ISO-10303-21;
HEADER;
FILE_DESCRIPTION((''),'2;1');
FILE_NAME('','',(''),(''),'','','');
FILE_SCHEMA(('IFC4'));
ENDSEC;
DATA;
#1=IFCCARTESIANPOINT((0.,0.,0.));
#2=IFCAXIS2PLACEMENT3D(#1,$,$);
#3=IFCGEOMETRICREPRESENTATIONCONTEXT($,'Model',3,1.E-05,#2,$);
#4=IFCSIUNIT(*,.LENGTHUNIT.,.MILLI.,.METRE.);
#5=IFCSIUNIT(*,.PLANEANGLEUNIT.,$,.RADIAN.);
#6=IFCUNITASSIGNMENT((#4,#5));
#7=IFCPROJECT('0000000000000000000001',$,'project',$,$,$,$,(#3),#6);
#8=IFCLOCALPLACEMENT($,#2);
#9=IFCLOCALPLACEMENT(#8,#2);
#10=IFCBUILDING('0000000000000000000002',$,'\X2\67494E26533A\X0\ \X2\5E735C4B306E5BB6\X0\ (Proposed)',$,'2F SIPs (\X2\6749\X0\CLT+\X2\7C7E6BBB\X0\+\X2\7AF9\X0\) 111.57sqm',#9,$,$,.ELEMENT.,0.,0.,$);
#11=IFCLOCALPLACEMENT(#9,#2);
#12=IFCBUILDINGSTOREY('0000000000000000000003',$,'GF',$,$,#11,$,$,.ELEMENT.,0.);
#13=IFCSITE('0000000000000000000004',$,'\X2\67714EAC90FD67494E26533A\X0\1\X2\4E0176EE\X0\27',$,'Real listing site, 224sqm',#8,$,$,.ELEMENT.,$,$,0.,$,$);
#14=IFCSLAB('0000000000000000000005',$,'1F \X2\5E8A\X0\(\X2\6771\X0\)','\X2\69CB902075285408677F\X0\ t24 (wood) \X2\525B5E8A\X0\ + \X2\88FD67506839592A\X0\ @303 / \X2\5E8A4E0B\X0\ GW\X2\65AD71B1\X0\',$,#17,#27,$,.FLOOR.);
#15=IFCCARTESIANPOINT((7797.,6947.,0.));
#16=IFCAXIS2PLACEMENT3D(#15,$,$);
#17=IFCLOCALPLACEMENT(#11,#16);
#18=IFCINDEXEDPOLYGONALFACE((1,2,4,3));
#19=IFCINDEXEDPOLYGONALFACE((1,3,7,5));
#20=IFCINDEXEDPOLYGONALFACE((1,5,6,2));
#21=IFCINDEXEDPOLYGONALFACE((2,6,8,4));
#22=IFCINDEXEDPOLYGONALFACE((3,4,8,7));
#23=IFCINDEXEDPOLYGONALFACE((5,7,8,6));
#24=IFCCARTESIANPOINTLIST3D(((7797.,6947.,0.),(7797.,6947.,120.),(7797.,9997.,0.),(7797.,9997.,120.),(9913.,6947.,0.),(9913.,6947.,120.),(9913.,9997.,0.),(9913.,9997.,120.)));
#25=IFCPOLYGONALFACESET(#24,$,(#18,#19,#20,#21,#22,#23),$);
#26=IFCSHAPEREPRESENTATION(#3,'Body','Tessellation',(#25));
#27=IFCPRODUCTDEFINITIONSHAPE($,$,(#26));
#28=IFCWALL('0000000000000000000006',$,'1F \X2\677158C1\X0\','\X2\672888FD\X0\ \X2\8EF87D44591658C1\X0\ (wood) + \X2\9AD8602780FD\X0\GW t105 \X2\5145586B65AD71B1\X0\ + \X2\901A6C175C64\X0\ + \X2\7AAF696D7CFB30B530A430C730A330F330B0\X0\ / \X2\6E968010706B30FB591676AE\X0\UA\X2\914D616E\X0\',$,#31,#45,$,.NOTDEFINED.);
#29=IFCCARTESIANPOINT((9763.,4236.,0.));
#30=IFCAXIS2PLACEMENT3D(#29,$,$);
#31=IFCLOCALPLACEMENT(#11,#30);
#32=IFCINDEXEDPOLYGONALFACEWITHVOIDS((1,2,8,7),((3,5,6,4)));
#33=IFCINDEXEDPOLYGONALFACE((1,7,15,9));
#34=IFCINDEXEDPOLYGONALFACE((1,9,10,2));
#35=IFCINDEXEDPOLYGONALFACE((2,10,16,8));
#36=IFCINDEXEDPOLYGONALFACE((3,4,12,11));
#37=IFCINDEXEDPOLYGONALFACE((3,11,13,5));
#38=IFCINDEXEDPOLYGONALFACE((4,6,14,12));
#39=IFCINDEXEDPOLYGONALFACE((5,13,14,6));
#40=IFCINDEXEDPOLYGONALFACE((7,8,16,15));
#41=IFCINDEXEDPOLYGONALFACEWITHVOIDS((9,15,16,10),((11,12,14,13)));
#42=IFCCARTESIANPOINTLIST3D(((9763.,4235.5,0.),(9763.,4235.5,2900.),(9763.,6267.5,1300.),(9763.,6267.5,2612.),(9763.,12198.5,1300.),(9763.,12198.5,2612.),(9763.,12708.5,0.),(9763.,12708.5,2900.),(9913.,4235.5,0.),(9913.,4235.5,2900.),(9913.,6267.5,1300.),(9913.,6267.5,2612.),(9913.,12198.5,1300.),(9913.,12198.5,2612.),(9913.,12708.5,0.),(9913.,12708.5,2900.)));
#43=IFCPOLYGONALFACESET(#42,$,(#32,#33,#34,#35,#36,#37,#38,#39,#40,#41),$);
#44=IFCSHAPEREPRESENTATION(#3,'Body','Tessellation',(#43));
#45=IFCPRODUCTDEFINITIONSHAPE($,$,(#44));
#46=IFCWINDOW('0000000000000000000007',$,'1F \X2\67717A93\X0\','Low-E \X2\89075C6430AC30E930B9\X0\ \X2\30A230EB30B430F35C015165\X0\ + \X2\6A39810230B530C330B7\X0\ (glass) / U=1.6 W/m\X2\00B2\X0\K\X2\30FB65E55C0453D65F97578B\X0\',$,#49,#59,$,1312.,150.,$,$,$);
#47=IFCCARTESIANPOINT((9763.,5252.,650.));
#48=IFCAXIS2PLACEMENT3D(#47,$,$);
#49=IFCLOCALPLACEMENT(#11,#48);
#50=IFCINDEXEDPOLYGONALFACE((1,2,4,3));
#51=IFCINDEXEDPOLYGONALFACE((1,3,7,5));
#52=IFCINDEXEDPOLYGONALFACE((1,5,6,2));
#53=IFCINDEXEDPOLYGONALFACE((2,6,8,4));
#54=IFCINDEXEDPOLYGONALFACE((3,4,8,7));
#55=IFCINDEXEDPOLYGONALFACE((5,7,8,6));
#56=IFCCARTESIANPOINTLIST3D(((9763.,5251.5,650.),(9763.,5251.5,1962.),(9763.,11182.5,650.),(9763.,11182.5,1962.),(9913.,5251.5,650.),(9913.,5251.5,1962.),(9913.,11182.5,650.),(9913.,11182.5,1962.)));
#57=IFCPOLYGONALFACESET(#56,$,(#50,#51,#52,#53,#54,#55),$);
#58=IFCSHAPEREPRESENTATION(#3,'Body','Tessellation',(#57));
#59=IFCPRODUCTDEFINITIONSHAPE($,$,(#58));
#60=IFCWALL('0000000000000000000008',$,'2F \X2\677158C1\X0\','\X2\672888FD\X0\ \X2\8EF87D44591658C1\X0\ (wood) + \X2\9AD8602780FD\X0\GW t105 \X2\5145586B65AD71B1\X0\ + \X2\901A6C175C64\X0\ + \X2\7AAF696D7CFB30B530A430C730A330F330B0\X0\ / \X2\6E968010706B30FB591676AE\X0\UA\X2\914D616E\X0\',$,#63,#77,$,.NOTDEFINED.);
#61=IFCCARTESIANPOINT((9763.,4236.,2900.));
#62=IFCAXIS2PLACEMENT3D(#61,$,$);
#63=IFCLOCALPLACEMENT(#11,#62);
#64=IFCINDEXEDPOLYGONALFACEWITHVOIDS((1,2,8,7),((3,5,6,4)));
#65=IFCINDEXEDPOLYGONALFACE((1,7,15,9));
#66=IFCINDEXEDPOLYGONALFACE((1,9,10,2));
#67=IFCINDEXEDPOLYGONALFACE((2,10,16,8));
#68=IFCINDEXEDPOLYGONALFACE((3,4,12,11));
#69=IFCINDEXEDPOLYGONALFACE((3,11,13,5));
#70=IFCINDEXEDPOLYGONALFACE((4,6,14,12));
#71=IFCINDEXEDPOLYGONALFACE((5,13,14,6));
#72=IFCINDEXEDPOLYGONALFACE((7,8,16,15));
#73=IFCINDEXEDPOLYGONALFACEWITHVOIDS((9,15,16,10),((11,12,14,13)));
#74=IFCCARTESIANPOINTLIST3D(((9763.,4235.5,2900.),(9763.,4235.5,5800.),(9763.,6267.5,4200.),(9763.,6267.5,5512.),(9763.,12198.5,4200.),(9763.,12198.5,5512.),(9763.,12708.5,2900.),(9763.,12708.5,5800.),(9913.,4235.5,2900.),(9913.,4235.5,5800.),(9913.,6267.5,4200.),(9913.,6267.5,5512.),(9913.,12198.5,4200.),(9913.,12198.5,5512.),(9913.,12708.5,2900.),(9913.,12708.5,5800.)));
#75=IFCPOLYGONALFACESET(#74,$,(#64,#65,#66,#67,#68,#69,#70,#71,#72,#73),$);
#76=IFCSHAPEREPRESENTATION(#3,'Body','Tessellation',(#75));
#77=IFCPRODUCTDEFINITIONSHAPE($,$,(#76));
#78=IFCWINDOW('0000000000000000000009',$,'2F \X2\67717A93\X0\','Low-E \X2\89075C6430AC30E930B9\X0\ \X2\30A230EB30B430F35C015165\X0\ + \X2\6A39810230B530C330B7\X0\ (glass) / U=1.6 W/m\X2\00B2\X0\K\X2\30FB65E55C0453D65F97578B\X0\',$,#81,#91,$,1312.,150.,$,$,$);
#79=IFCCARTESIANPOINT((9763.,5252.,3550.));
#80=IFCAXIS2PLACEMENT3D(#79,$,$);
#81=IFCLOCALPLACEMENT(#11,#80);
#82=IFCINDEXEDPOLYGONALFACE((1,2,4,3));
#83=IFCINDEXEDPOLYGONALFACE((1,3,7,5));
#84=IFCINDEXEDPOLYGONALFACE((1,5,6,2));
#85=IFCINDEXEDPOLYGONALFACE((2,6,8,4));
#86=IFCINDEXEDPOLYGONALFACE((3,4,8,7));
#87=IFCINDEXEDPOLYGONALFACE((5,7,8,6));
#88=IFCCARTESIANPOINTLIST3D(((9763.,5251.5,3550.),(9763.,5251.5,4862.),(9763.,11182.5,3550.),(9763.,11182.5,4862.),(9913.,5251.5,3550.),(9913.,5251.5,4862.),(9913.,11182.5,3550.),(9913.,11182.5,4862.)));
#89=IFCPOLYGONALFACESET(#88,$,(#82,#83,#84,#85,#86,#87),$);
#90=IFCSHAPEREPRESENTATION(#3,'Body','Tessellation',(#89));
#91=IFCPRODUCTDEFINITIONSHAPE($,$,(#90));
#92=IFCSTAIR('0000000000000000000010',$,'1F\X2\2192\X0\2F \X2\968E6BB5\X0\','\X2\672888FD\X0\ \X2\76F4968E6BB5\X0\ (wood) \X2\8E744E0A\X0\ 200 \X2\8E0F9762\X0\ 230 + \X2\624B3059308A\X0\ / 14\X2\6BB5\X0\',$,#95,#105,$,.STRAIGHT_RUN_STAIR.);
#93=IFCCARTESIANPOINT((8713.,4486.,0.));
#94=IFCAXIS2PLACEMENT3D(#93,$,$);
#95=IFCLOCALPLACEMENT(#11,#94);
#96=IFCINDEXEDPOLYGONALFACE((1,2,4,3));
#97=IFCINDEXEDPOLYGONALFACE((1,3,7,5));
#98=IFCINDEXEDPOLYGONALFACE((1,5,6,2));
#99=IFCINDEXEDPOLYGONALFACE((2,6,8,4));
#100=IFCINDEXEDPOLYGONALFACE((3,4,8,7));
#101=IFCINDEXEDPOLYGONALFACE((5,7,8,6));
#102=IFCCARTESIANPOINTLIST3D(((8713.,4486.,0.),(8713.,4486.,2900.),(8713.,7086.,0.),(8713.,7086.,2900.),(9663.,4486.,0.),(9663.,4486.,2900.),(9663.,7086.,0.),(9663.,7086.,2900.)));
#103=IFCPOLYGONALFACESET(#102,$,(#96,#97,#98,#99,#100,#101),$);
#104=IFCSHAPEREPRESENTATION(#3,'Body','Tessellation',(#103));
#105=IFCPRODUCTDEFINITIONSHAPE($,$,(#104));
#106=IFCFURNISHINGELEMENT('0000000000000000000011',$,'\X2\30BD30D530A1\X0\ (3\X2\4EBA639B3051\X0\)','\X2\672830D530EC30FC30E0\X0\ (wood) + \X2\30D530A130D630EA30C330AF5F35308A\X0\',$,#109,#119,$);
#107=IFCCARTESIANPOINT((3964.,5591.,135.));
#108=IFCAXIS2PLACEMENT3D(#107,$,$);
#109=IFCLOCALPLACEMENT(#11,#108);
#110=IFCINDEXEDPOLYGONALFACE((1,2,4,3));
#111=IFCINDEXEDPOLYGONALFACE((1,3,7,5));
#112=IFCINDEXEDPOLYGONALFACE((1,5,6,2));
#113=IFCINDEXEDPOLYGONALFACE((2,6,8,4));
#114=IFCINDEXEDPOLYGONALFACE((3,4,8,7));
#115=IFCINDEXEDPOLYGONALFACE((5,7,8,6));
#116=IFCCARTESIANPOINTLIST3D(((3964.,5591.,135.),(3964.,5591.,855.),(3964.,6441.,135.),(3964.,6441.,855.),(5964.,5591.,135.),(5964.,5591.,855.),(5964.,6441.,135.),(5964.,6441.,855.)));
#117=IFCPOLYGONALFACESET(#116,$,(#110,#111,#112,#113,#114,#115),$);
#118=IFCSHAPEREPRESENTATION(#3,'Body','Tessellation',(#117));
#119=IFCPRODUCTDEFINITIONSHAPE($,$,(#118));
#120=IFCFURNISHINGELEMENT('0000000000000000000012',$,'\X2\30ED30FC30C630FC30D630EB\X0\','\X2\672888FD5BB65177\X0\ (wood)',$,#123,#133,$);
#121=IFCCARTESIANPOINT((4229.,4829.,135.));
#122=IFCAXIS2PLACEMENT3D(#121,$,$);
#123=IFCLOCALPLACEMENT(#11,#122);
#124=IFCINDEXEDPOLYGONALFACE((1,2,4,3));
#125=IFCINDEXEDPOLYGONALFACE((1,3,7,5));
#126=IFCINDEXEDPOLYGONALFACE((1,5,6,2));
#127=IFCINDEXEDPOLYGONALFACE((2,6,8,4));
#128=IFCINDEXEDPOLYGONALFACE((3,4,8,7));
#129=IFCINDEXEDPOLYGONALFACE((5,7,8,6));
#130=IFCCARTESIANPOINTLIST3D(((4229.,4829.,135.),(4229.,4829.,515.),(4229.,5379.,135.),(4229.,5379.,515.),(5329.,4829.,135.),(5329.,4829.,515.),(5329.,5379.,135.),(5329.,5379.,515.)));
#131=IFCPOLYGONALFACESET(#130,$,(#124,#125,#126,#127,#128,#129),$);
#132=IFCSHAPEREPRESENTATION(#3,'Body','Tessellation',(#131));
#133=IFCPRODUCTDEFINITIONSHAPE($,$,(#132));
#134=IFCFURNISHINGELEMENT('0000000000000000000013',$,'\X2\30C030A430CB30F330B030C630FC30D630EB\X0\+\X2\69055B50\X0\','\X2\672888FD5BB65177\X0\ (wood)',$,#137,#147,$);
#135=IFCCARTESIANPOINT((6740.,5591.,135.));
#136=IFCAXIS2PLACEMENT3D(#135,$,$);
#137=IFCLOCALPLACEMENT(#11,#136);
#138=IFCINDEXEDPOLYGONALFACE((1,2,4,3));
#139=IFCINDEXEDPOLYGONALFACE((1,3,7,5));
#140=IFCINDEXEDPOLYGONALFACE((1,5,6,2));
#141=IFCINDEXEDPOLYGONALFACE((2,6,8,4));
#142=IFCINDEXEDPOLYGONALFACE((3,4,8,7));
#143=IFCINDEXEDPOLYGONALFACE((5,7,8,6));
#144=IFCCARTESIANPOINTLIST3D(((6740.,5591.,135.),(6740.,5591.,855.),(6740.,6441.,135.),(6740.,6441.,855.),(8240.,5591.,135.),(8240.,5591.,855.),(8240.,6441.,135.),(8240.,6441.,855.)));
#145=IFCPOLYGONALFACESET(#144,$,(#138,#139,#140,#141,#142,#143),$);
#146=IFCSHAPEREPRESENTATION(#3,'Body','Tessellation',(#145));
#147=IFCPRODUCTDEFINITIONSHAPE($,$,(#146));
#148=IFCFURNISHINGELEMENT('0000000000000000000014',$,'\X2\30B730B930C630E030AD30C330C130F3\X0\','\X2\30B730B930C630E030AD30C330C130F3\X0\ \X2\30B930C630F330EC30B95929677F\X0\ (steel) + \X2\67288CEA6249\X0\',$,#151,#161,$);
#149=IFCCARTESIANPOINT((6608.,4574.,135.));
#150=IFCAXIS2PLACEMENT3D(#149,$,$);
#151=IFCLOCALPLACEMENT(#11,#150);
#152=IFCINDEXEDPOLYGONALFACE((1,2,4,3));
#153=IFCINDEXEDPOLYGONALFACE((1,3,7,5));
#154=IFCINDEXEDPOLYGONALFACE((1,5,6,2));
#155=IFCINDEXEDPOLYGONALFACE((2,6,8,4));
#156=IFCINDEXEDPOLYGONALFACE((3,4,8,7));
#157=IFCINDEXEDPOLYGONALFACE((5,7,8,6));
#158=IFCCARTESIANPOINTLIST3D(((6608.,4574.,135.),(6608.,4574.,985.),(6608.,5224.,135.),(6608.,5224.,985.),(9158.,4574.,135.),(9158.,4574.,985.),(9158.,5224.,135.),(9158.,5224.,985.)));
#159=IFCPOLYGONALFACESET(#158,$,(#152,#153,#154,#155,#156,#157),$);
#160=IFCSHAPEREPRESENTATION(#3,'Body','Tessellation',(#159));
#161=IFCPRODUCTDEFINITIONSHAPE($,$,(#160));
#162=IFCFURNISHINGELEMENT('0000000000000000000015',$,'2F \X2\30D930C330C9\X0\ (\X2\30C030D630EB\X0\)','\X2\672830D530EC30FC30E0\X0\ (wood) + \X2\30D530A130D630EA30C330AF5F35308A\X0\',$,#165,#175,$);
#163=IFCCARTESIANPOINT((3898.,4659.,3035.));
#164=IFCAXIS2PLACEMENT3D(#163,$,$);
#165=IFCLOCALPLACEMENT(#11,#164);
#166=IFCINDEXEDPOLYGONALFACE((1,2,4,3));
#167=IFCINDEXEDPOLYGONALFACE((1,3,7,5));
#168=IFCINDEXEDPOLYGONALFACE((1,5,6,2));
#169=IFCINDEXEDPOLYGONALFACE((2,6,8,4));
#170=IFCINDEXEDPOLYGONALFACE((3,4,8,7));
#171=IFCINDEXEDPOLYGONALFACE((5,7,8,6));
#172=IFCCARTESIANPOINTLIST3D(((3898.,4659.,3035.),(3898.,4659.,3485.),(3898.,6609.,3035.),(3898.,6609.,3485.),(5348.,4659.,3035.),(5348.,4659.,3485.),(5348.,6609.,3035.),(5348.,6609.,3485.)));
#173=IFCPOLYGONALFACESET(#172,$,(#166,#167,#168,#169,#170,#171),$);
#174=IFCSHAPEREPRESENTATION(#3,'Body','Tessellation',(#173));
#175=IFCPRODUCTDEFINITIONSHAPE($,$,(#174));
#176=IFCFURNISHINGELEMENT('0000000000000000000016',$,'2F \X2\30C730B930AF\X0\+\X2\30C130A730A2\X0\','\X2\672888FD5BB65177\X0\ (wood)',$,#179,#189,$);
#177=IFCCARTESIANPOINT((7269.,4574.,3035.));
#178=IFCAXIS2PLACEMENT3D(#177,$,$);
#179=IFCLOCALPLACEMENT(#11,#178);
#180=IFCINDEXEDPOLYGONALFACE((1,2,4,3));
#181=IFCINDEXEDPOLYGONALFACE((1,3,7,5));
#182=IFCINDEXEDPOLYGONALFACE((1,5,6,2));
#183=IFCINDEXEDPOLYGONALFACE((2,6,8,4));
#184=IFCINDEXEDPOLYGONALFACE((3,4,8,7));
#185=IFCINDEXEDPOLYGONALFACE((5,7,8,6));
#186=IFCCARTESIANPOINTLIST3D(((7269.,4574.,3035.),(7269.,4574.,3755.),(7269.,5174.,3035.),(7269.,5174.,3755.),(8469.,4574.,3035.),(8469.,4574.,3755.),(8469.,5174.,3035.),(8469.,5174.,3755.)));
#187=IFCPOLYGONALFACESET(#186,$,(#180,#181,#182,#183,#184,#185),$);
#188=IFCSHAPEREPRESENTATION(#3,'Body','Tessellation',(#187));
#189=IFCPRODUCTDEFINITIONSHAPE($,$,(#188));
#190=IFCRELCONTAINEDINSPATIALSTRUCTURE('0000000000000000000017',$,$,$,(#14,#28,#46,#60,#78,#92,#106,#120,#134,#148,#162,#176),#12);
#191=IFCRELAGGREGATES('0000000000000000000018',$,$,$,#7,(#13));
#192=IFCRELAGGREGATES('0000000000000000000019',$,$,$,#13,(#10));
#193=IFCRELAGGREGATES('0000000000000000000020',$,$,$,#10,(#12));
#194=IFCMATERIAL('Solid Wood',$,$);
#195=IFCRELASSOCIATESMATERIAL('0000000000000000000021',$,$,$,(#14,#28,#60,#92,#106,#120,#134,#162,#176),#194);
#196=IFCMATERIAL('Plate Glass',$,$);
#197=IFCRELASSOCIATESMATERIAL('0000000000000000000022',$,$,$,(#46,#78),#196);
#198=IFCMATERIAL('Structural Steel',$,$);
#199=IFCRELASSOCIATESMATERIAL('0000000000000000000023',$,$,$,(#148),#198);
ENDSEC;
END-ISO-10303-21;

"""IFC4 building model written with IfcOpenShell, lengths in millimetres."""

from ifc_helpers import new_model, si_unit, frame, frame_2d, origin, place, context, project, spatial, rectangle, extrude, material, element, fill, save


model = new_model("IFC4")

# Units and contexts
model_context = context("Model", 3, precision=1e-05, world=origin())
ifc_project = project(units=[si_unit("LENGTHUNIT", "METRE", prefix="MILLI"), si_unit("PLANEANGLEUNIT", "RADIAN")], contexts=[model_context])

# Site, building, storey
site_placement = place(None, origin())
site = spatial("IfcSite", under=ifc_project, at=site_placement, Name="東京都杉並区1丁目27", ObjectType="Real listing site, 224sqm", CompositionType="ELEMENT", RefElevation=0.0)
building_placement = place(site_placement, origin())
building = spatial("IfcBuilding", under=site, at=building_placement, Name="杉並区 平屋の家 (Proposed)", ObjectType="2F SIPs (杉CLT+籾殻+竹) 111.57sqm", CompositionType="ELEMENT", ElevationOfRefHeight=0.0, ElevationOfTerrain=0.0)
storey_placement = place(building_placement, origin())
storey = spatial("IfcBuildingStorey", under=building, at=storey_placement, Name="GF", CompositionType="ELEMENT", Elevation=0.0)

# Slab
ifc_material_1 = material(Name="Solid Wood")
slab_placement = place(storey_placement, frame((7797.0, 6947.0, 0.0)))
element("IfcSlab", 1, at=slab_placement, inside=storey, material=ifc_material_1, Name="1F 床(東)", Description="構造用合板 t24 (wood) 剛床 + 製材根太 @303 / 床下 GW断熱", PredefinedType="FLOOR", context=model_context, shape_type="SweptSolid", body=[
    extrude(rectangle(XDim=2116.0, YDim=3050.0, at=frame_2d((1058.0, 1525.0))), frame((7797.0, 6947.0, 0.0)), (0.0, 0.0, 1.0), 120.0),
])

# Wall, opening, window
wall_1_placement = place(storey_placement, frame((9763.0, 4236.0, 0.0)))
wall_1 = element("IfcWall", 2, at=wall_1_placement, inside=storey, material=ifc_material_1, Name="1F 東壁", Description="木製 軸組外壁 (wood) + 高性能GW t105 充填断熱 + 通気層 + 窯業系サイディング / 準耐火・外皮UA配慮", PredefinedType="NOTDEFINED", context=model_context, shape_type="SweptSolid", body=[
    extrude(rectangle(XDim=150.0, YDim=8473.0, at=frame_2d((75.0, 4236.0))), frame((9763.0, 4236.0, 0.0)), (0.0, 0.0, 1.0), 2900.0),
])
opening_1_placement = place(storey_placement, frame((9763.0, 5252.0, 650.0)))
opening_1 = element("IfcOpeningElement", 3, at=opening_1_placement, cuts=wall_1, PredefinedType="NOTDEFINED", context=model_context, shape_type="SweptSolid", body=[
    extrude(rectangle(XDim=150.0, YDim=5931.0, at=frame_2d((75.0, 2965.0))), frame((9763.0, 5252.0, 650.0)), (0.0, 0.0, 1.0), 1312.0),
])
ifc_material_2 = material(Name="Plate Glass")
window_1_placement = place(storey_placement, frame((9763.0, 5252.0, 650.0)))
window_1 = element("IfcWindow", 4, at=window_1_placement, inside=storey, material=ifc_material_2, Name="1F 東窓", Description="Low-E 複層ガラス アルゴン封入 + 樹脂サッシ (glass) / U=1.6 W/m²K・日射取得型", OverallHeight=1312.0, OverallWidth=150.0, context=model_context, shape_type="SweptSolid", body=[
    extrude(rectangle(XDim=150.0, YDim=5931.0, at=frame_2d((75.0, 2965.0))), frame((9763.0, 5252.0, 650.0)), (0.0, 0.0, 1.0), 1312.0),
])
fill(opening_1, window_1)

# Wall, opening, window
wall_2_placement = place(storey_placement, frame((9763.0, 4236.0, 2900.0)))
wall_2 = element("IfcWall", 5, at=wall_2_placement, inside=storey, material=ifc_material_1, Name="2F 東壁", Description="木製 軸組外壁 (wood) + 高性能GW t105 充填断熱 + 通気層 + 窯業系サイディング / 準耐火・外皮UA配慮", PredefinedType="NOTDEFINED", context=model_context, shape_type="SweptSolid", body=[
    extrude(rectangle(XDim=150.0, YDim=8473.0, at=frame_2d((75.0, 4236.0))), frame((9763.0, 4236.0, 2900.0)), (0.0, 0.0, 1.0), 2900.0),
])
opening_2_placement = place(storey_placement, frame((9763.0, 5252.0, 3550.0)))
opening_2 = element("IfcOpeningElement", 6, at=opening_2_placement, cuts=wall_2, PredefinedType="NOTDEFINED", context=model_context, shape_type="SweptSolid", body=[
    extrude(rectangle(XDim=150.0, YDim=5931.0, at=frame_2d((75.0, 2965.0))), frame((9763.0, 5252.0, 3550.0)), (0.0, 0.0, 1.0), 1312.0),
])
window_2_placement = place(storey_placement, frame((9763.0, 5252.0, 3550.0)))
window_2 = element("IfcWindow", 7, at=window_2_placement, inside=storey, material=ifc_material_2, Name="2F 東窓", Description="Low-E 複層ガラス アルゴン封入 + 樹脂サッシ (glass) / U=1.6 W/m²K・日射取得型", OverallHeight=1312.0, OverallWidth=150.0, context=model_context, shape_type="SweptSolid", body=[
    extrude(rectangle(XDim=150.0, YDim=5931.0, at=frame_2d((75.0, 2965.0))), frame((9763.0, 5252.0, 3550.0)), (0.0, 0.0, 1.0), 1312.0),
])
fill(opening_2, window_2)

# Stair
stair_placement = place(storey_placement, frame((8713.0, 4486.0, 0.0)))
element("IfcStair", 8, at=stair_placement, inside=storey, material=ifc_material_1, Name="1F→2F 階段", Description="木製 直階段 (wood) 蹴上 200 踏面 230 + 手すり / 14段", PredefinedType="STRAIGHT_RUN_STAIR", context=model_context, shape_type="SweptSolid", body=[
    extrude(rectangle(XDim=950.0, YDim=2600.0, at=frame_2d((475.0, 1300.0))), frame((8713.0, 4486.0, 0.0)), (0.0, 0.0, 1.0), 2900.0),
])

# Furnishing elements
furnishing_1_placement = place(storey_placement, frame((3964.0, 5591.0, 135.0)))
element("IfcFurnishingElement", 9, at=furnishing_1_placement, inside=storey, material=ifc_material_1, Name="ソファ (3人掛け)", Description="木フレーム (wood) + ファブリック張り", context=model_context, shape_type="SweptSolid", body=[
    extrude(rectangle(XDim=2000.0, YDim=850.0, at=frame_2d((1000.0, 425.0))), frame((3964.0, 5591.0, 135.0)), (0.0, 0.0, 1.0), 720.0),
])
furnishing_2_placement = place(storey_placement, frame((4229.0, 4829.0, 135.0)))
element("IfcFurnishingElement", 10, at=furnishing_2_placement, inside=storey, material=ifc_material_1, Name="ローテーブル", Description="木製家具 (wood)", context=model_context, shape_type="SweptSolid", body=[
    extrude(rectangle(XDim=1100.0, YDim=550.0, at=frame_2d((550.0, 275.0))), frame((4229.0, 4829.0, 135.0)), (0.0, 0.0, 1.0), 380.0),
])
furnishing_3_placement = place(storey_placement, frame((6740.0, 5591.0, 135.0)))
element("IfcFurnishingElement", 11, at=furnishing_3_placement, inside=storey, material=ifc_material_1, Name="ダイニングテーブル+椅子", Description="木製家具 (wood)", context=model_context, shape_type="SweptSolid", body=[
    extrude(rectangle(XDim=1500.0, YDim=850.0, at=frame_2d((750.0, 425.0))), frame((6740.0, 5591.0, 135.0)), (0.0, 0.0, 1.0), 720.0),
])
ifc_material_3 = material(Name="Structural Steel")
furnishing_4_placement = place(storey_placement, frame((6608.0, 4574.0, 135.0)))
element("IfcFurnishingElement", 12, at=furnishing_4_placement, inside=storey, material=ifc_material_3, Name="システムキッチン", Description="システムキッチン ステンレス天板 (steel) + 木質扉", context=model_context, shape_type="SweptSolid", body=[
    extrude(rectangle(XDim=2550.0, YDim=650.0, at=frame_2d((1275.0, 325.0))), frame((6608.0, 4574.0, 135.0)), (0.0, 0.0, 1.0), 850.0),
])
furnishing_5_placement = place(storey_placement, frame((3898.0, 4659.0, 3035.0)))
element("IfcFurnishingElement", 13, at=furnishing_5_placement, inside=storey, material=ifc_material_1, Name="2F ベッド (ダブル)", Description="木フレーム (wood) + ファブリック張り", context=model_context, shape_type="SweptSolid", body=[
    extrude(rectangle(XDim=1450.0, YDim=1950.0, at=frame_2d((725.0, 975.0))), frame((3898.0, 4659.0, 3035.0)), (0.0, 0.0, 1.0), 450.0),
])
furnishing_6_placement = place(storey_placement, frame((7269.0, 4574.0, 3035.0)))
element("IfcFurnishingElement", 14, at=furnishing_6_placement, inside=storey, material=ifc_material_1, Name="2F デスク+チェア", Description="木製家具 (wood)", context=model_context, shape_type="SweptSolid", body=[
    extrude(rectangle(XDim=1200.0, YDim=600.0, at=frame_2d((600.0, 300.0))), frame((7269.0, 4574.0, 3035.0)), (0.0, 0.0, 1.0), 720.0),
])

save(model, "model.ifc")
